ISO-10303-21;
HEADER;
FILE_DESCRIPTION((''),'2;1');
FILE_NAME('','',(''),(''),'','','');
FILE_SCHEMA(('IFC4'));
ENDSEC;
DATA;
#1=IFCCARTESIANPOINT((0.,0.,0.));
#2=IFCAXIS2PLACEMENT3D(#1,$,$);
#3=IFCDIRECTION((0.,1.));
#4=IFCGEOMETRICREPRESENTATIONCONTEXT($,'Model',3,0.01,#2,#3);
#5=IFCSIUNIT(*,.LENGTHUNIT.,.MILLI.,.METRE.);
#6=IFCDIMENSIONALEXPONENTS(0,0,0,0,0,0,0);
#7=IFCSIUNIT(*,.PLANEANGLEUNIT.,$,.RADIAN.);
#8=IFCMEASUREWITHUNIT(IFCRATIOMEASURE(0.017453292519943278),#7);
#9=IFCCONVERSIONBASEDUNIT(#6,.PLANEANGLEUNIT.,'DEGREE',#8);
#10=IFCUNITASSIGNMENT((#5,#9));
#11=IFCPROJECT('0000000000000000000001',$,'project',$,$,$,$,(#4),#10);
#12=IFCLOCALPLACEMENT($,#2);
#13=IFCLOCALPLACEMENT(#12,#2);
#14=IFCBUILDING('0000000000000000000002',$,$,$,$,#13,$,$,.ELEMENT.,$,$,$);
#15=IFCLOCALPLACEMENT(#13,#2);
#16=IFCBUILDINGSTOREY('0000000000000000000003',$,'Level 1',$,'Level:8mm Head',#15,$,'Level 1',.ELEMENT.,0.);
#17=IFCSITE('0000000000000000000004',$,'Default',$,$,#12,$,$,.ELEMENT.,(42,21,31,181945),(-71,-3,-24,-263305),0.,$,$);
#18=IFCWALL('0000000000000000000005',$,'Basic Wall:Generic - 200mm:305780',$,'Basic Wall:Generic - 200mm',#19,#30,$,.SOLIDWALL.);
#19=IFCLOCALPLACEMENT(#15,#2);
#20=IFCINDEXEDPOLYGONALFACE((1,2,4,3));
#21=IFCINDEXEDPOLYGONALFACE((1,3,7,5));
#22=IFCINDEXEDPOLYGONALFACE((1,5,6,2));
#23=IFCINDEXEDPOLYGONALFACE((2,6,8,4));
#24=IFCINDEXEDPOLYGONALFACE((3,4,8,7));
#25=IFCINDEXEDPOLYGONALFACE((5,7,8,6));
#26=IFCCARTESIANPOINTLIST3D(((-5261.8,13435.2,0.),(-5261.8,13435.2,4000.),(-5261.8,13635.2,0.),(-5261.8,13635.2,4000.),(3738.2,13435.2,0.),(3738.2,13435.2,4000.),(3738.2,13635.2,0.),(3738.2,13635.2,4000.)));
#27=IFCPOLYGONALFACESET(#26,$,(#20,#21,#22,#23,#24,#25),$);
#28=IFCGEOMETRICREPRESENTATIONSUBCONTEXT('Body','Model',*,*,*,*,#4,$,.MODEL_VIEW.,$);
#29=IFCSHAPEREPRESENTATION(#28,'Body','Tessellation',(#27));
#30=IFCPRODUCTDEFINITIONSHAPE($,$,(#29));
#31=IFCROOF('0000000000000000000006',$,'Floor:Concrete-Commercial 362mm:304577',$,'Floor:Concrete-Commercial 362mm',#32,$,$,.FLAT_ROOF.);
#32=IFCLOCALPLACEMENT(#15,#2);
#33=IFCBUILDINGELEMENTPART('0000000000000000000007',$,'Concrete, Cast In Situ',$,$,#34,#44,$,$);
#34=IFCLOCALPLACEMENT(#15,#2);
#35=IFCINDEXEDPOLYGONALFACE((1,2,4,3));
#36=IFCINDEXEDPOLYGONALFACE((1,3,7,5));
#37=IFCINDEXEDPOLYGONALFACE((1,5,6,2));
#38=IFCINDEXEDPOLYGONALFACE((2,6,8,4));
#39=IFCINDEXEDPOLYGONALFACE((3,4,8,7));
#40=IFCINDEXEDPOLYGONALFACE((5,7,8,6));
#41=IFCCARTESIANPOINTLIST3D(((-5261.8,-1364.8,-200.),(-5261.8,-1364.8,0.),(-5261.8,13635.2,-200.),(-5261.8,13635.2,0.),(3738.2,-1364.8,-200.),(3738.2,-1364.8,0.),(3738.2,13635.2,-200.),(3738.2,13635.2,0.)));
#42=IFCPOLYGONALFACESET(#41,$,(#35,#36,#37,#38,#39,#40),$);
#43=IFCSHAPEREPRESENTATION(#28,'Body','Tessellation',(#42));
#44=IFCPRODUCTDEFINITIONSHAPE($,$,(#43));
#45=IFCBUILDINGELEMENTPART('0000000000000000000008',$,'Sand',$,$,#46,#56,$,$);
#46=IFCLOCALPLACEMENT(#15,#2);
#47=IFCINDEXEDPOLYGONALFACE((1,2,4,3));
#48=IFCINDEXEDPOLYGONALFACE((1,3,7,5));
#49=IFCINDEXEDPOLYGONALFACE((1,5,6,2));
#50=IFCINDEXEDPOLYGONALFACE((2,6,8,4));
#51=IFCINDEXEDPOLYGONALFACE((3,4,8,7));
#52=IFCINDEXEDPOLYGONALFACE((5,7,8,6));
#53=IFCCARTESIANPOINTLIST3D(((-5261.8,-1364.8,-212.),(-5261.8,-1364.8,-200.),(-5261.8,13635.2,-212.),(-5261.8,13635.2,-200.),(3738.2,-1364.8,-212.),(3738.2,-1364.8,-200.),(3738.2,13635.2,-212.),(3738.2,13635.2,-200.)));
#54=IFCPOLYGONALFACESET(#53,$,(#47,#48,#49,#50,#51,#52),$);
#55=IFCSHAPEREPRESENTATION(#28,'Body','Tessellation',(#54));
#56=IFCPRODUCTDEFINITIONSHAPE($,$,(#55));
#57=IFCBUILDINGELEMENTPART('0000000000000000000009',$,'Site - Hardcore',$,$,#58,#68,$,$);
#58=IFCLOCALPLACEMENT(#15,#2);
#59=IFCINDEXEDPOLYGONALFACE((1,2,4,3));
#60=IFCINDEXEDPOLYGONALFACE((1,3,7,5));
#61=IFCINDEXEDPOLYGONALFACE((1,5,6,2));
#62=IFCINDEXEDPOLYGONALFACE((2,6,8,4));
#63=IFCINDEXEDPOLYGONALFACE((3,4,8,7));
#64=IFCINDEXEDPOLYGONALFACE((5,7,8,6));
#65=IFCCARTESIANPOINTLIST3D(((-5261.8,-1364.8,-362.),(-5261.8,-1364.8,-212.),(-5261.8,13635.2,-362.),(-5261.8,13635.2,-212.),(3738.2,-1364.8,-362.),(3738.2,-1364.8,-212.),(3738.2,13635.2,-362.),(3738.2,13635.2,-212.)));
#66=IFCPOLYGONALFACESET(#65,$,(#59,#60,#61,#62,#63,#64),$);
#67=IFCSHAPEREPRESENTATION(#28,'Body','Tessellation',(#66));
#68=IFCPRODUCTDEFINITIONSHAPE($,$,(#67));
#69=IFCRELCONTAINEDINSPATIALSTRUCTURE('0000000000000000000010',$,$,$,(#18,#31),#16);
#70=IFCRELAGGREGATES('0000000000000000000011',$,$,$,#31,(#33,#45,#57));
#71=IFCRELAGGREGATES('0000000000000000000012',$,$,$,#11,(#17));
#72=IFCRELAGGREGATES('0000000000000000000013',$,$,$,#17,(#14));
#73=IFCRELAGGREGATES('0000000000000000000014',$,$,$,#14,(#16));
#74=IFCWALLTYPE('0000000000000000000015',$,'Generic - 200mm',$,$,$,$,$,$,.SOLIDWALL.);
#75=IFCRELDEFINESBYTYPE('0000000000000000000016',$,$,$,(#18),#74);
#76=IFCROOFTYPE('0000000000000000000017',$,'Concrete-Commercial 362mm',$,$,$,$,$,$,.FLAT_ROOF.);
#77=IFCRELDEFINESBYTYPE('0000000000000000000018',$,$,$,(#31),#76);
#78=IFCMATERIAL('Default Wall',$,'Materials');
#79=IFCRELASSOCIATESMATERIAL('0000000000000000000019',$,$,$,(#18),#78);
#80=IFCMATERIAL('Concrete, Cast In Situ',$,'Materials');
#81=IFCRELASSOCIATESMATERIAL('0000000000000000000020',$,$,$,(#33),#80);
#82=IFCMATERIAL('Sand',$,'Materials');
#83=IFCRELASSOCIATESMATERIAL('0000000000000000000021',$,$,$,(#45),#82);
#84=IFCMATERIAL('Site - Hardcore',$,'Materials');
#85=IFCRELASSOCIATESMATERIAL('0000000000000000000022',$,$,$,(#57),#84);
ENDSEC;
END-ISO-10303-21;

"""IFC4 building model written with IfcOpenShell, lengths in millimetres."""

from ifc_helpers import new_model, entity, si_unit, converted_unit, direction, frame, origin, place, context, subcontext, project, spatial, indexed_curve, outline, extrude, material, type_object, element, aggregate, save


model = new_model("IFC4")

# Units and contexts
model_context = context("Model", 3, precision=0.01, world=origin(), true_north=direction((0.0, 1.0)))
body_context = subcontext(model_context, "Body", "Model", "MODEL_VIEW")
ifc_project = project(units=[si_unit("LENGTHUNIT", "METRE", prefix="MILLI"), converted_unit("PLANEANGLEUNIT", "DEGREE", entity("IfcRatioMeasure", 0.017453292519943278), si_unit("PLANEANGLEUNIT", "RADIAN"), dimensions=[0, 0, 0, 0, 0, 0, 0])], contexts=[model_context])

# Site, building, storey
site_placement = place(None, origin())
site = spatial("IfcSite", under=ifc_project, at=site_placement, Name="Default", CompositionType="ELEMENT", RefLatitude=(42, 21, 31, 181945), RefLongitude=(-71, -3, -24, -263305), RefElevation=0.0)
building_placement = place(site_placement, origin())
building = spatial("IfcBuilding", under=site, at=building_placement, CompositionType="ELEMENT")
storey_placement = place(building_placement, origin())
storey = spatial("IfcBuildingStorey", under=building, at=storey_placement, Name="Level 1", ObjectType="Level:8mm Head", LongName="Level 1", CompositionType="ELEMENT", Elevation=0.0)

# Wall
ifc_material_1 = material(Name="Default Wall", Category="Materials")
wall_type = type_object("IfcWallType", Name="Generic - 200mm", PredefinedType="SOLIDWALL")
wall_placement = place(storey_placement, frame((-5261.8, 13535.2, 0.0)))
element("IfcWall", 1, at=wall_placement, inside=storey, type_object=wall_type, material=ifc_material_1, Name="Basic Wall:Generic - 200mm:305780", ObjectType="Basic Wall:Generic - 200mm", PredefinedType="SOLIDWALL", context=body_context, shape_type="SweptSolid", body=[
    extrude(outline(indexed_curve([(9000.0, 100.0), (0.0, 100.0), (0.0, -100.0), (9000.0, -100.0), (9000.0, 100.0)], self_intersect=False)), origin(), (0.0, 0.0, 1.0), 4000.0),
])

# Roof, building element parts
roof_type = type_object("IfcRoofType", Name="Concrete-Commercial 362mm", PredefinedType="FLAT_ROOF")
roof_placement = place(storey_placement, origin())
roof = element("IfcRoof", 2, at=roof_placement, inside=storey, type_object=roof_type, Name="Floor:Concrete-Commercial 362mm:304577", ObjectType="Floor:Concrete-Commercial 362mm", PredefinedType="FLAT_ROOF")
ifc_material_2 = material(Name="Concrete, Cast In Situ", Category="Materials")
building_element_part_1_placement = place(roof_placement, origin())
building_element_part_1 = element("IfcBuildingElementPart", 3, at=building_element_part_1_placement, material=ifc_material_2, Name="Concrete, Cast In Situ", context=body_context, shape_type="SweptSolid", body=[
    extrude(outline(indexed_curve([(-4500.0, -7500.0), (4500.0, -7500.0), (4500.0, 7500.0), (-4500.0, 7500.0), (-4500.0, -7500.0)], self_intersect=False)), frame((-761.8, 6135.2, -200.0), z_axis=(0.0, 0.0, 1.0), x_axis=(-1.0, 0.0, 0.0)), (0.0, 0.0, 1.0), 200.0),
])
ifc_material_3 = material(Name="Sand", Category="Materials")
building_element_part_2_placement = place(roof_placement, origin())
building_element_part_2 = element("IfcBuildingElementPart", 4, at=building_element_part_2_placement, material=ifc_material_3, Name="Sand", context=body_context, shape_type="SweptSolid", body=[
    extrude(outline(indexed_curve([(-4500.0, -7500.0), (4500.0, -7500.0), (4500.0, 7500.0), (-4500.0, 7500.0), (-4500.0, -7500.0)], self_intersect=False)), frame((-761.8, 6135.2, -212.0), z_axis=(0.0, 0.0, 1.0), x_axis=(-1.0, 0.0, 0.0)), (0.0, 0.0, 1.0), 12.0),
])
ifc_material_4 = material(Name="Site - Hardcore", Category="Materials")
building_element_part_3_placement = place(roof_placement, origin())
building_element_part_3 = element("IfcBuildingElementPart", 5, at=building_element_part_3_placement, material=ifc_material_4, Name="Site - Hardcore", context=body_context, shape_type="SweptSolid", body=[
    extrude(outline(indexed_curve([(-4500.0, -7500.0), (4500.0, -7500.0), (4500.0, 7500.0), (-4500.0, 7500.0), (-4500.0, -7500.0)], self_intersect=False)), frame((-761.8, 6135.2, -362.0), z_axis=(0.0, 0.0, 1.0), x_axis=(-1.0, 0.0, 0.0)), (0.0, 0.0, 1.0), 150.0),
])
aggregate(roof, [building_element_part_1, building_element_part_2, building_element_part_3])

save(model, "model.ifc")
